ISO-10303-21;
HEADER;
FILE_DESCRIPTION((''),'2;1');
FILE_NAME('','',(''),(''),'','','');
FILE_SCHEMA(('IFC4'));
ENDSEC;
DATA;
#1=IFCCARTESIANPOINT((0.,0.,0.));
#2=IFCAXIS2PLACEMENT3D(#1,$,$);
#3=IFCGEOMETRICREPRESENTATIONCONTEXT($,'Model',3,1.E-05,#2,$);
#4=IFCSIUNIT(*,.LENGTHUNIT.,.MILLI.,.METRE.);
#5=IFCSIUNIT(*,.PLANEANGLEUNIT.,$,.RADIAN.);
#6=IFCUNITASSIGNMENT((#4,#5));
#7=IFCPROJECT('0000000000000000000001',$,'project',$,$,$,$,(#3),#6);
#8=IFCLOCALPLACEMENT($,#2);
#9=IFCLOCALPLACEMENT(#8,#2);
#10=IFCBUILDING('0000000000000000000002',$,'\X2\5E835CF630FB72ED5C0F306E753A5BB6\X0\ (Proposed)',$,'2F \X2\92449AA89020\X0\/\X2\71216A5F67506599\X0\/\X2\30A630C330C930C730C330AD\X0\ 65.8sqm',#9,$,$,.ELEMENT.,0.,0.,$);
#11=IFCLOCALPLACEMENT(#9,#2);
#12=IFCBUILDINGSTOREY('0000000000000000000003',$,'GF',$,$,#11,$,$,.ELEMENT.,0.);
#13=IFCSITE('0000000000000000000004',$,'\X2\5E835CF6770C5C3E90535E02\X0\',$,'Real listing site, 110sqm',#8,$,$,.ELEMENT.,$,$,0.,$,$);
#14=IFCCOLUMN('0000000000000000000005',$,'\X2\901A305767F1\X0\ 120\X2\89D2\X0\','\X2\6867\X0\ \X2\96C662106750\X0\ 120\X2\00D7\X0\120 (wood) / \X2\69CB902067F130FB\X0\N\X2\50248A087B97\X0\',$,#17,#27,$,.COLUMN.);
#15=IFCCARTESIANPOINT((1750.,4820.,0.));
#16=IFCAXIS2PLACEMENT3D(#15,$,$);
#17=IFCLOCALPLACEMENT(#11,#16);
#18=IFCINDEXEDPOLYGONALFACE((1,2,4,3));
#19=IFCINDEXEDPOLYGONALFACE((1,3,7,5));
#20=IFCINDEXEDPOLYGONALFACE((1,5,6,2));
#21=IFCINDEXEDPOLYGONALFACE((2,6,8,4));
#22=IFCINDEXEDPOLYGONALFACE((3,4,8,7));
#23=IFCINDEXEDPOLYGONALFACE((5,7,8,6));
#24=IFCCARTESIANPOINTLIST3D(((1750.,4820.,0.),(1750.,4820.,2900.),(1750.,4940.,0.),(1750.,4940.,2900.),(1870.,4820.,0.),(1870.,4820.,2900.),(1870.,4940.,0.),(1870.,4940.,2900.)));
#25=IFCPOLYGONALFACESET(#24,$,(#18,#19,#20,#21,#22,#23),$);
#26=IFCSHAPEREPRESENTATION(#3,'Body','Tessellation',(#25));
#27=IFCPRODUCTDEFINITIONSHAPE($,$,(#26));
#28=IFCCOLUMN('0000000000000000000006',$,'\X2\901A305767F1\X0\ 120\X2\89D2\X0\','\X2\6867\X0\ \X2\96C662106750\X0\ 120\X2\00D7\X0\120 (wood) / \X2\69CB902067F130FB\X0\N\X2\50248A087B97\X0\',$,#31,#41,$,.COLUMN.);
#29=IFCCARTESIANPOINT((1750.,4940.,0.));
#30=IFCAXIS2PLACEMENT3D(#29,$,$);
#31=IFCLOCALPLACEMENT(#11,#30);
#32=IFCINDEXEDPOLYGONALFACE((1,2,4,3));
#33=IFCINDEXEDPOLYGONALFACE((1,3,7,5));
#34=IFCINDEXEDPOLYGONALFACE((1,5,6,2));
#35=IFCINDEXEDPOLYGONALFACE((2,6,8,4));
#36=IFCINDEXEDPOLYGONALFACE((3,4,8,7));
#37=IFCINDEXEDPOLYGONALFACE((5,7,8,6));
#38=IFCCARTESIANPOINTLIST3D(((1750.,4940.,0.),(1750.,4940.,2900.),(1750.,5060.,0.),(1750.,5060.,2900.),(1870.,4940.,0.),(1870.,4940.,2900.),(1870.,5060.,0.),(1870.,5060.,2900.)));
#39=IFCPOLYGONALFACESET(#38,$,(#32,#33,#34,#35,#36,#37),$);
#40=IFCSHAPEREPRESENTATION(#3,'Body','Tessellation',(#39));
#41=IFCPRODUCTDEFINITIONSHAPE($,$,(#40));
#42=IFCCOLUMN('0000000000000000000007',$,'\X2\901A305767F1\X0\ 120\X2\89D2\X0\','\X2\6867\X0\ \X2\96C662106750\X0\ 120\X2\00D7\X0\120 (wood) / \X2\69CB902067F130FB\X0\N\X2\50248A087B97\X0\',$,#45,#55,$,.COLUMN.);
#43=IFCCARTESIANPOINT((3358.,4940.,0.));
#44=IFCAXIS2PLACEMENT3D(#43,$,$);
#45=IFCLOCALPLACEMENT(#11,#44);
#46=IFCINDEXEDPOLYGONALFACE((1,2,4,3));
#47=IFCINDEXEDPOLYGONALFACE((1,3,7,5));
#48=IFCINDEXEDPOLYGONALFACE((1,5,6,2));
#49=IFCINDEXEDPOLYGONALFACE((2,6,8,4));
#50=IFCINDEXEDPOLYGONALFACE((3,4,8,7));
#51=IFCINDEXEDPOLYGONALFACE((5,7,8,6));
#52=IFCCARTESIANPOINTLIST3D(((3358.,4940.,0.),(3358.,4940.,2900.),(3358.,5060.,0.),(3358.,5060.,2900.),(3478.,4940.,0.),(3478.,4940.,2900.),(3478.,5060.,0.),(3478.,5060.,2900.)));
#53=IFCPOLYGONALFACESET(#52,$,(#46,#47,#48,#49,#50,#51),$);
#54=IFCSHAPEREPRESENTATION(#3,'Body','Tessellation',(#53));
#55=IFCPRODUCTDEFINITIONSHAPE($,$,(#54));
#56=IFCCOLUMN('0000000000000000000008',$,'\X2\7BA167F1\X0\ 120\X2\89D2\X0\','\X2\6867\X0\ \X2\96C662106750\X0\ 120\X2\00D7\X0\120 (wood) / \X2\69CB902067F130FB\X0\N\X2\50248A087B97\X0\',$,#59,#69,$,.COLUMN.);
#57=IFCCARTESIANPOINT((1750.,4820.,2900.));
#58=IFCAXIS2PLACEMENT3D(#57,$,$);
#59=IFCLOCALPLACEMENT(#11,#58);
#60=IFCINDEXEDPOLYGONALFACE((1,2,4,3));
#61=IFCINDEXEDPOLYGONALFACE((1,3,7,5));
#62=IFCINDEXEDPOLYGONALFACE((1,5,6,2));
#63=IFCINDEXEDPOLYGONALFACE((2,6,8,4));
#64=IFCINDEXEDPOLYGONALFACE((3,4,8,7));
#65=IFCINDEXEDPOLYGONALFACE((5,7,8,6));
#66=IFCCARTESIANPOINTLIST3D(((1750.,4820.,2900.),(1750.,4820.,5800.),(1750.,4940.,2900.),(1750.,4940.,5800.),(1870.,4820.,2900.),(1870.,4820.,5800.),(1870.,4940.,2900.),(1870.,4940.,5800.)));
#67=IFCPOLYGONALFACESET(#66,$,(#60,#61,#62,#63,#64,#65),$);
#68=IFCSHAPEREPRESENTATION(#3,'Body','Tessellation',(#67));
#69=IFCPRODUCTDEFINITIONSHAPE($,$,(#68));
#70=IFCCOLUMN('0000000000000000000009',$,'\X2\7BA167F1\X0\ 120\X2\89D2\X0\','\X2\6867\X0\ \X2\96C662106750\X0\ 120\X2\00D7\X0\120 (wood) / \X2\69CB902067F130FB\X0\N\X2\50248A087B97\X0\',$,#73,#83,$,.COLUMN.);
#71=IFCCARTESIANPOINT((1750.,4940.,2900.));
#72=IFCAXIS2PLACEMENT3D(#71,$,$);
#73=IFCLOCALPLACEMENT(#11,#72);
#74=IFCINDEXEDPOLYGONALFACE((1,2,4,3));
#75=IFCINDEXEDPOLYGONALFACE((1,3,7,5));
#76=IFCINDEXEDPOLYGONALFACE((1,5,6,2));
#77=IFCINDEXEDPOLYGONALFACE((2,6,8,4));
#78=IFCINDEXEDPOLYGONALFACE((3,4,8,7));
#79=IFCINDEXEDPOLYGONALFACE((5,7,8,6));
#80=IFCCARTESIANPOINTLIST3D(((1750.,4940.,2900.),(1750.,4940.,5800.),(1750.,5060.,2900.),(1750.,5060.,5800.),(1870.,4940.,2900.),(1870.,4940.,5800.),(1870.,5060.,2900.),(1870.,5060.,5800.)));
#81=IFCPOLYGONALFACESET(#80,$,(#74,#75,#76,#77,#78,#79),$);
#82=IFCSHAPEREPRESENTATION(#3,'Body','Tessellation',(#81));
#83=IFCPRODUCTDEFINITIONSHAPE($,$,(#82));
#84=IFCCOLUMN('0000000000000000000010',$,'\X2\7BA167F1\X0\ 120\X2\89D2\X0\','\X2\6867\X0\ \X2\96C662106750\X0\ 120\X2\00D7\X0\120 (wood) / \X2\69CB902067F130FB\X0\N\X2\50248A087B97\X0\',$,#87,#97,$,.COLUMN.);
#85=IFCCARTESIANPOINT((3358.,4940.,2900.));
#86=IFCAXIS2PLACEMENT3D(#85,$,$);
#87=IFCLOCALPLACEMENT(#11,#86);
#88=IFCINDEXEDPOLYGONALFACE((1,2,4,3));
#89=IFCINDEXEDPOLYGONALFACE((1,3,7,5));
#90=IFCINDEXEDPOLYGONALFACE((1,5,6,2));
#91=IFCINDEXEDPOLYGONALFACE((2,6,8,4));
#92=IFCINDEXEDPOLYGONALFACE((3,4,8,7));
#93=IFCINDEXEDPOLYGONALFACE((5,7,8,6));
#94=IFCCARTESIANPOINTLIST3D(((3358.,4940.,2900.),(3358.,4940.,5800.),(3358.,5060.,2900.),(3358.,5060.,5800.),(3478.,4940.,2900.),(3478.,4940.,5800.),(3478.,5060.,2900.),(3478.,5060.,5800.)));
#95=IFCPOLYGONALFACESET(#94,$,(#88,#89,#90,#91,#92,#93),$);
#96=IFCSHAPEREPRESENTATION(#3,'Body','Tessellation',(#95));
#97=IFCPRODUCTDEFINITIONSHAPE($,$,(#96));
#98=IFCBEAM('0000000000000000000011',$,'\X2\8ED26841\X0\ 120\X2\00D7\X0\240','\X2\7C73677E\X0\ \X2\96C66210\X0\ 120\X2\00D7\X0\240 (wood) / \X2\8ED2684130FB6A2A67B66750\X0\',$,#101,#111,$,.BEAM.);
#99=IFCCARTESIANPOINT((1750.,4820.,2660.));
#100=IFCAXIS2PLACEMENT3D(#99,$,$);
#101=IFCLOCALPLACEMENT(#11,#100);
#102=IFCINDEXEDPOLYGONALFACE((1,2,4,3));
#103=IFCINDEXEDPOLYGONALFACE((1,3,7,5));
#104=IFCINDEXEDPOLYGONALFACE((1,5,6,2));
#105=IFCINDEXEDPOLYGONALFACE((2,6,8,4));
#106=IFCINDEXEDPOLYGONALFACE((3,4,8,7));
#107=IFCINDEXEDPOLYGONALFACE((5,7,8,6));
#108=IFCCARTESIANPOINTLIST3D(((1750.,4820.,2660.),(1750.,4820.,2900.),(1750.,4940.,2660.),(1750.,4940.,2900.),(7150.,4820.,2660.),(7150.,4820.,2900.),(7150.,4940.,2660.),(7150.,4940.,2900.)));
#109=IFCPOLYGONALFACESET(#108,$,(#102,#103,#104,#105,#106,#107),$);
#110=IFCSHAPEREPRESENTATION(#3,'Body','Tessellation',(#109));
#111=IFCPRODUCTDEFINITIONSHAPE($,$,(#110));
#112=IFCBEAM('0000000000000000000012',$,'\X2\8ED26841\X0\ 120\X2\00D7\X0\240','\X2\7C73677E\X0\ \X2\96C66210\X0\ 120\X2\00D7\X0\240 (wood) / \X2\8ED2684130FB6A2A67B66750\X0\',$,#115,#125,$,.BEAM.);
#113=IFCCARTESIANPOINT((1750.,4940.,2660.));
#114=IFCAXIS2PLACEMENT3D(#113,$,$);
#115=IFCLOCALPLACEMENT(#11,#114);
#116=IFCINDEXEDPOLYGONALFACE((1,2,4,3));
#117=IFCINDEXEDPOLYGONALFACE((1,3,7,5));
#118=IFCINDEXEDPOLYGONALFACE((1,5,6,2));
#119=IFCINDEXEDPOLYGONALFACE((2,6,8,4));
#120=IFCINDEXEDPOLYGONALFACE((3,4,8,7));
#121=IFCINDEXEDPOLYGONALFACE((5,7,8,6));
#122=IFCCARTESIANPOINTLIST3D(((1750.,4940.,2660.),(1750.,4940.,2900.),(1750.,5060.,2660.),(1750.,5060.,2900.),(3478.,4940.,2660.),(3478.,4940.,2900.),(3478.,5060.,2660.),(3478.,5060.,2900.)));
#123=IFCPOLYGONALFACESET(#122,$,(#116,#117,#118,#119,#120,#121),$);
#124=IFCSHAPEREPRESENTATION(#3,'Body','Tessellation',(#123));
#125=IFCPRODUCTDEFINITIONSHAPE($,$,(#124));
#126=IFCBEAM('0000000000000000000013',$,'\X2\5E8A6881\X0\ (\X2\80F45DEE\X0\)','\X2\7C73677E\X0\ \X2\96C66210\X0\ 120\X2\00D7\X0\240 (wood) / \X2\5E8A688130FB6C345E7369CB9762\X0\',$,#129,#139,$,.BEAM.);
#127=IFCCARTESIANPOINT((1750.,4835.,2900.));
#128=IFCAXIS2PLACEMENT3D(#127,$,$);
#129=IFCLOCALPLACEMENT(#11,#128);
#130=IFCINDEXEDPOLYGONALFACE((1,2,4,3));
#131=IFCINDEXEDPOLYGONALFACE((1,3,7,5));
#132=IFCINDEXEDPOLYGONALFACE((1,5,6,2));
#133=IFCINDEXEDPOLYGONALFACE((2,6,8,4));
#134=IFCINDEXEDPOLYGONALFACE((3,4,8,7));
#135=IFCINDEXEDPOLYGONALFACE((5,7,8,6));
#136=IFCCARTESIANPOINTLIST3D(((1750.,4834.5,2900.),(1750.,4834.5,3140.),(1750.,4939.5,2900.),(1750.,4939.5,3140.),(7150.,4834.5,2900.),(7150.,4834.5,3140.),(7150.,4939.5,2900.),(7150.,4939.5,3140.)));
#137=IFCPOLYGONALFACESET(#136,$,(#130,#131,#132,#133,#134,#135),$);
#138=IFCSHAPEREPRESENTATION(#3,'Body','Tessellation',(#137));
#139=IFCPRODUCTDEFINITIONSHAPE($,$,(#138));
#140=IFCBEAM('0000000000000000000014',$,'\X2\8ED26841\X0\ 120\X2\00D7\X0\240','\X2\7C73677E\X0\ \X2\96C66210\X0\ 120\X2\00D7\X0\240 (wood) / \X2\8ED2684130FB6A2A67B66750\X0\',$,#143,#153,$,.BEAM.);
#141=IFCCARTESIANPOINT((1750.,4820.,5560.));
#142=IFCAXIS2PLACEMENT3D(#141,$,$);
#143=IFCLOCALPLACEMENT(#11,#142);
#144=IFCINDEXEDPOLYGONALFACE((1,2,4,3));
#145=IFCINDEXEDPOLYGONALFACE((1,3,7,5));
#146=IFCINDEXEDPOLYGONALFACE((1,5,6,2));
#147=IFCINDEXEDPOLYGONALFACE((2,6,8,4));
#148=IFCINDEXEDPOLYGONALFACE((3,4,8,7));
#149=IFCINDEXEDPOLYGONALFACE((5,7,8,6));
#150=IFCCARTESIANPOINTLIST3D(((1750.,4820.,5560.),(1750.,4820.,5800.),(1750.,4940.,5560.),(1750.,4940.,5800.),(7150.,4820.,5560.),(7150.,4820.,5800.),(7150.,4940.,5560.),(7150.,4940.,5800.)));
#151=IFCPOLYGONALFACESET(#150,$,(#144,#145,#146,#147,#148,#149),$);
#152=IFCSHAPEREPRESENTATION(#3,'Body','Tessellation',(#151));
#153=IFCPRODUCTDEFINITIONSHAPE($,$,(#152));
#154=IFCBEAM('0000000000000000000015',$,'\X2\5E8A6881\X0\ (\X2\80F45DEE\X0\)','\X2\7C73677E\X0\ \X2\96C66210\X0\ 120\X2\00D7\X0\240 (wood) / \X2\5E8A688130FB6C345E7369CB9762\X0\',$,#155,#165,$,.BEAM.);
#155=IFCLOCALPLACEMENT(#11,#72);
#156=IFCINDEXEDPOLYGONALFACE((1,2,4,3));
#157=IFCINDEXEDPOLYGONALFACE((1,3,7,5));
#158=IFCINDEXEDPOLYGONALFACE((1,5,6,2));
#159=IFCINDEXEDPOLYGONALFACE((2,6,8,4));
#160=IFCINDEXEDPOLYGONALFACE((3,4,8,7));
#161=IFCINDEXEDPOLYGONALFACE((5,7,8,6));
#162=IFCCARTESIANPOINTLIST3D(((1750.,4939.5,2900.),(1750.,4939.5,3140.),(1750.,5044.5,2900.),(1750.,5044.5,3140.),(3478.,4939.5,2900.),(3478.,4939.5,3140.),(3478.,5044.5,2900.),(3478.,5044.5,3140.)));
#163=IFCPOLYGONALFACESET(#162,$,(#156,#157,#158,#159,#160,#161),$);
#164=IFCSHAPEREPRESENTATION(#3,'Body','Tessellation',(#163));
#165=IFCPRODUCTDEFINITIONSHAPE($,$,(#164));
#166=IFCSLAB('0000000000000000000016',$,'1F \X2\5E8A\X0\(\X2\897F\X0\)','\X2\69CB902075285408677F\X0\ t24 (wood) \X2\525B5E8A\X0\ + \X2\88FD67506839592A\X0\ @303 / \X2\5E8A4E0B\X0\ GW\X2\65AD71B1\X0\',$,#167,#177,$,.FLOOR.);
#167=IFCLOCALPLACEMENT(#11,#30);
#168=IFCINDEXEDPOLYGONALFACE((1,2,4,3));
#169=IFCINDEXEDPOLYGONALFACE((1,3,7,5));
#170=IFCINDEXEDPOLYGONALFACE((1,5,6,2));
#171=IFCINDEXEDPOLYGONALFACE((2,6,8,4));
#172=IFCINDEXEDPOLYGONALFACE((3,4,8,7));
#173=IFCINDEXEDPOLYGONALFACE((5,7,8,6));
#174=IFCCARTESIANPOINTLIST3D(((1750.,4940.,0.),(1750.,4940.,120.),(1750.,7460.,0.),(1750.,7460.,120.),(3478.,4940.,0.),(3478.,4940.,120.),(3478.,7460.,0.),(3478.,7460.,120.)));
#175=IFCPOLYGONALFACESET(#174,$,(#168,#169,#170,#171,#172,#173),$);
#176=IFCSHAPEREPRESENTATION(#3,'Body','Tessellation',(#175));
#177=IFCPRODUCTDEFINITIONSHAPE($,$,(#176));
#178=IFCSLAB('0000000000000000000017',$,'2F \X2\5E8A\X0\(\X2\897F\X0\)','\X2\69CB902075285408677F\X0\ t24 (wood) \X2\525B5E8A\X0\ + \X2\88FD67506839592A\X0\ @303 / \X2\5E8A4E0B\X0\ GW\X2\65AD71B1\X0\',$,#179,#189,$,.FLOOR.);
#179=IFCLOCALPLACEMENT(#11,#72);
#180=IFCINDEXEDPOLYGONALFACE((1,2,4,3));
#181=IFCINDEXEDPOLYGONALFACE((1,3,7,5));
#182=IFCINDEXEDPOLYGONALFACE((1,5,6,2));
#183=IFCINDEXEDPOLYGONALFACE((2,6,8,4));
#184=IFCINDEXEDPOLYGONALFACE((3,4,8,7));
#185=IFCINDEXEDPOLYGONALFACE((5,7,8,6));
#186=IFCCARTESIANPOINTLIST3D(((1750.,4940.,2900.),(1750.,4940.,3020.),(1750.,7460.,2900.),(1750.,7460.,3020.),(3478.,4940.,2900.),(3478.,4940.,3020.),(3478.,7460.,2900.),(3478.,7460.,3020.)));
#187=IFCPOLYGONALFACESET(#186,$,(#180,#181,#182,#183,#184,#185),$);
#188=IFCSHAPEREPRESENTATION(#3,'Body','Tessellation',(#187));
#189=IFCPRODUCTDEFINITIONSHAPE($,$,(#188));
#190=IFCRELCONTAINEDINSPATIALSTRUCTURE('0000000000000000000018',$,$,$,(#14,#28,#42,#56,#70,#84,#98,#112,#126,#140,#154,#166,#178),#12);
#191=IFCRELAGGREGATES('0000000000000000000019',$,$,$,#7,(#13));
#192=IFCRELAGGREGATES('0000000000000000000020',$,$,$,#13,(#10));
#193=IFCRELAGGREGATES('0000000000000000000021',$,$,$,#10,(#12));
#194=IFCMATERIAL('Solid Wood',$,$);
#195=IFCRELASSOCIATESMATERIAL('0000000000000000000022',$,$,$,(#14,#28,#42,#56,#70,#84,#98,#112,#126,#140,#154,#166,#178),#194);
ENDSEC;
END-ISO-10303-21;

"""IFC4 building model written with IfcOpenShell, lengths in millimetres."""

from ifc_helpers import new_model, si_unit, frame, frame_2d, origin, place, context, project, spatial, rectangle, extrude, material, element, save


model = new_model("IFC4")

# Units and contexts
model_context = context("Model", 3, precision=1e-05, world=origin())
ifc_project = project(units=[si_unit("LENGTHUNIT", "METRE", prefix="MILLI"), si_unit("PLANEANGLEUNIT", "RADIAN")], contexts=[model_context])

# Site, building, storey
site_placement = place(None, origin())
site = spatial("IfcSite", under=ifc_project, at=site_placement, Name="広島県尾道市", ObjectType="Real listing site, 110sqm", CompositionType="ELEMENT", RefElevation=0.0)
building_placement = place(site_placement, origin())
building = spatial("IfcBuilding", under=site, at=building_placement, Name="広島・狭小の町家 (Proposed)", ObjectType="2F 鉄骨造/無機材料/ウッドデッキ 65.8sqm", CompositionType="ELEMENT", ElevationOfRefHeight=0.0, ElevationOfTerrain=0.0)
storey_placement = place(building_placement, origin())
storey = spatial("IfcBuildingStorey", under=building, at=storey_placement, Name="GF", CompositionType="ELEMENT", Elevation=0.0)

# Columns
ifc_material_1 = material(Name="Solid Wood")
column_1_placement = place(storey_placement, frame((1750.0, 4820.0, 0.0)))
element("IfcColumn", 1, at=column_1_placement, inside=storey, material=ifc_material_1, Name="通し柱 120角", Description="桧 集成材 120×120 (wood) / 構造柱・N値計算", PredefinedType="COLUMN", context=model_context, shape_type="SweptSolid", body=[
    extrude(rectangle(XDim=120.0, YDim=120.0, at=frame_2d((60.0, 60.0))), frame((1750.0, 4820.0, 0.0)), (0.0, 0.0, 1.0), 2900.0),
])
column_2_placement = place(storey_placement, frame((1750.0, 4940.0, 0.0)))
element("IfcColumn", 2, at=column_2_placement, inside=storey, material=ifc_material_1, Name="通し柱 120角", Description="桧 集成材 120×120 (wood) / 構造柱・N値計算", PredefinedType="COLUMN", context=model_context, shape_type="SweptSolid", body=[
    extrude(rectangle(XDim=120.0, YDim=120.0, at=frame_2d((60.0, 60.0))), frame((1750.0, 4940.0, 0.0)), (0.0, 0.0, 1.0), 2900.0),
])
column_3_placement = place(storey_placement, frame((3358.0, 4940.0, 0.0)))
element("IfcColumn", 3, at=column_3_placement, inside=storey, material=ifc_material_1, Name="通し柱 120角", Description="桧 集成材 120×120 (wood) / 構造柱・N値計算", PredefinedType="COLUMN", context=model_context, shape_type="SweptSolid", body=[
    extrude(rectangle(XDim=120.0, YDim=120.0, at=frame_2d((60.0, 60.0))), frame((3358.0, 4940.0, 0.0)), (0.0, 0.0, 1.0), 2900.0),
])
column_4_placement = place(storey_placement, frame((1750.0, 4820.0, 2900.0)))
element("IfcColumn", 4, at=column_4_placement, inside=storey, material=ifc_material_1, Name="管柱 120角", Description="桧 集成材 120×120 (wood) / 構造柱・N値計算", PredefinedType="COLUMN", context=model_context, shape_type="SweptSolid", body=[
    extrude(rectangle(XDim=120.0, YDim=120.0, at=frame_2d((60.0, 60.0))), frame((1750.0, 4820.0, 2900.0)), (0.0, 0.0, 1.0), 2900.0),
])
column_5_placement = place(storey_placement, frame((1750.0, 4940.0, 2900.0)))
element("IfcColumn", 5, at=column_5_placement, inside=storey, material=ifc_material_1, Name="管柱 120角", Description="桧 集成材 120×120 (wood) / 構造柱・N値計算", PredefinedType="COLUMN", context=model_context, shape_type="SweptSolid", body=[
    extrude(rectangle(XDim=120.0, YDim=120.0, at=frame_2d((60.0, 60.0))), frame((1750.0, 4940.0, 2900.0)), (0.0, 0.0, 1.0), 2900.0),
])
column_6_placement = place(storey_placement, frame((3358.0, 4940.0, 2900.0)))
element("IfcColumn", 6, at=column_6_placement, inside=storey, material=ifc_material_1, Name="管柱 120角", Description="桧 集成材 120×120 (wood) / 構造柱・N値計算", PredefinedType="COLUMN", context=model_context, shape_type="SweptSolid", body=[
    extrude(rectangle(XDim=120.0, YDim=120.0, at=frame_2d((60.0, 60.0))), frame((3358.0, 4940.0, 2900.0)), (0.0, 0.0, 1.0), 2900.0),
])

# Beams
beam_1_placement = place(storey_placement, frame((1750.0, 4820.0, 2660.0)))
element("IfcBeam", 7, at=beam_1_placement, inside=storey, material=ifc_material_1, Name="軒桁 120×240", Description="米松 集成 120×240 (wood) / 軒桁・横架材", PredefinedType="BEAM", context=model_context, shape_type="SweptSolid", body=[
    extrude(rectangle(XDim=5400.0, YDim=120.0, at=frame_2d((2700.0, 60.0))), frame((1750.0, 4820.0, 2660.0)), (0.0, 0.0, 1.0), 240.0),
])
beam_2_placement = place(storey_placement, frame((1750.0, 4940.0, 2660.0)))
element("IfcBeam", 8, at=beam_2_placement, inside=storey, material=ifc_material_1, Name="軒桁 120×240", Description="米松 集成 120×240 (wood) / 軒桁・横架材", PredefinedType="BEAM", context=model_context, shape_type="SweptSolid", body=[
    extrude(rectangle(XDim=1728.0, YDim=120.0, at=frame_2d((864.0, 60.0))), frame((1750.0, 4940.0, 2660.0)), (0.0, 0.0, 1.0), 240.0),
])
beam_3_placement = place(storey_placement, frame((1750.0, 4835.0, 2900.0)))
element("IfcBeam", 9, at=beam_3_placement, inside=storey, material=ifc_material_1, Name="床梁 (胴差)", Description="米松 集成 120×240 (wood) / 床梁・水平構面", PredefinedType="BEAM", context=model_context, shape_type="SweptSolid", body=[
    extrude(rectangle(XDim=5400.0, YDim=105.0, at=frame_2d((2700.0, 52.0))), frame((1750.0, 4835.0, 2900.0)), (0.0, 0.0, 1.0), 240.0),
])
beam_4_placement = place(storey_placement, frame((1750.0, 4820.0, 5560.0)))
element("IfcBeam", 10, at=beam_4_placement, inside=storey, material=ifc_material_1, Name="軒桁 120×240", Description="米松 集成 120×240 (wood) / 軒桁・横架材", PredefinedType="BEAM", context=model_context, shape_type="SweptSolid", body=[
    extrude(rectangle(XDim=5400.0, YDim=120.0, at=frame_2d((2700.0, 60.0))), frame((1750.0, 4820.0, 5560.0)), (0.0, 0.0, 1.0), 240.0),
])
beam_5_placement = place(storey_placement, frame((1750.0, 4940.0, 2900.0)))
element("IfcBeam", 11, at=beam_5_placement, inside=storey, material=ifc_material_1, Name="床梁 (胴差)", Description="米松 集成 120×240 (wood) / 床梁・水平構面", PredefinedType="BEAM", context=model_context, shape_type="SweptSolid", body=[
    extrude(rectangle(XDim=1728.0, YDim=105.0, at=frame_2d((864.0, 52.0))), frame((1750.0, 4940.0, 2900.0)), (0.0, 0.0, 1.0), 240.0),
])

# Slabs
slab_1_placement = place(storey_placement, frame((1750.0, 4940.0, 0.0)))
element("IfcSlab", 12, at=slab_1_placement, inside=storey, material=ifc_material_1, Name="1F 床(西)", Description="構造用合板 t24 (wood) 剛床 + 製材根太 @303 / 床下 GW断熱", PredefinedType="FLOOR", context=model_context, shape_type="SweptSolid", body=[
    extrude(rectangle(XDim=1728.0, YDim=2520.0, at=frame_2d((864.0, 1260.0))), frame((1750.0, 4940.0, 0.0)), (0.0, 0.0, 1.0), 120.0),
])
slab_2_placement = place(storey_placement, frame((1750.0, 4940.0, 2900.0)))
element("IfcSlab", 13, at=slab_2_placement, inside=storey, material=ifc_material_1, Name="2F 床(西)", Description="構造用合板 t24 (wood) 剛床 + 製材根太 @303 / 床下 GW断熱", PredefinedType="FLOOR", context=model_context, shape_type="SweptSolid", body=[
    extrude(rectangle(XDim=1728.0, YDim=2520.0, at=frame_2d((864.0, 1260.0))), frame((1750.0, 4940.0, 2900.0)), (0.0, 0.0, 1.0), 120.0),
])

save(model, "model.ifc")
